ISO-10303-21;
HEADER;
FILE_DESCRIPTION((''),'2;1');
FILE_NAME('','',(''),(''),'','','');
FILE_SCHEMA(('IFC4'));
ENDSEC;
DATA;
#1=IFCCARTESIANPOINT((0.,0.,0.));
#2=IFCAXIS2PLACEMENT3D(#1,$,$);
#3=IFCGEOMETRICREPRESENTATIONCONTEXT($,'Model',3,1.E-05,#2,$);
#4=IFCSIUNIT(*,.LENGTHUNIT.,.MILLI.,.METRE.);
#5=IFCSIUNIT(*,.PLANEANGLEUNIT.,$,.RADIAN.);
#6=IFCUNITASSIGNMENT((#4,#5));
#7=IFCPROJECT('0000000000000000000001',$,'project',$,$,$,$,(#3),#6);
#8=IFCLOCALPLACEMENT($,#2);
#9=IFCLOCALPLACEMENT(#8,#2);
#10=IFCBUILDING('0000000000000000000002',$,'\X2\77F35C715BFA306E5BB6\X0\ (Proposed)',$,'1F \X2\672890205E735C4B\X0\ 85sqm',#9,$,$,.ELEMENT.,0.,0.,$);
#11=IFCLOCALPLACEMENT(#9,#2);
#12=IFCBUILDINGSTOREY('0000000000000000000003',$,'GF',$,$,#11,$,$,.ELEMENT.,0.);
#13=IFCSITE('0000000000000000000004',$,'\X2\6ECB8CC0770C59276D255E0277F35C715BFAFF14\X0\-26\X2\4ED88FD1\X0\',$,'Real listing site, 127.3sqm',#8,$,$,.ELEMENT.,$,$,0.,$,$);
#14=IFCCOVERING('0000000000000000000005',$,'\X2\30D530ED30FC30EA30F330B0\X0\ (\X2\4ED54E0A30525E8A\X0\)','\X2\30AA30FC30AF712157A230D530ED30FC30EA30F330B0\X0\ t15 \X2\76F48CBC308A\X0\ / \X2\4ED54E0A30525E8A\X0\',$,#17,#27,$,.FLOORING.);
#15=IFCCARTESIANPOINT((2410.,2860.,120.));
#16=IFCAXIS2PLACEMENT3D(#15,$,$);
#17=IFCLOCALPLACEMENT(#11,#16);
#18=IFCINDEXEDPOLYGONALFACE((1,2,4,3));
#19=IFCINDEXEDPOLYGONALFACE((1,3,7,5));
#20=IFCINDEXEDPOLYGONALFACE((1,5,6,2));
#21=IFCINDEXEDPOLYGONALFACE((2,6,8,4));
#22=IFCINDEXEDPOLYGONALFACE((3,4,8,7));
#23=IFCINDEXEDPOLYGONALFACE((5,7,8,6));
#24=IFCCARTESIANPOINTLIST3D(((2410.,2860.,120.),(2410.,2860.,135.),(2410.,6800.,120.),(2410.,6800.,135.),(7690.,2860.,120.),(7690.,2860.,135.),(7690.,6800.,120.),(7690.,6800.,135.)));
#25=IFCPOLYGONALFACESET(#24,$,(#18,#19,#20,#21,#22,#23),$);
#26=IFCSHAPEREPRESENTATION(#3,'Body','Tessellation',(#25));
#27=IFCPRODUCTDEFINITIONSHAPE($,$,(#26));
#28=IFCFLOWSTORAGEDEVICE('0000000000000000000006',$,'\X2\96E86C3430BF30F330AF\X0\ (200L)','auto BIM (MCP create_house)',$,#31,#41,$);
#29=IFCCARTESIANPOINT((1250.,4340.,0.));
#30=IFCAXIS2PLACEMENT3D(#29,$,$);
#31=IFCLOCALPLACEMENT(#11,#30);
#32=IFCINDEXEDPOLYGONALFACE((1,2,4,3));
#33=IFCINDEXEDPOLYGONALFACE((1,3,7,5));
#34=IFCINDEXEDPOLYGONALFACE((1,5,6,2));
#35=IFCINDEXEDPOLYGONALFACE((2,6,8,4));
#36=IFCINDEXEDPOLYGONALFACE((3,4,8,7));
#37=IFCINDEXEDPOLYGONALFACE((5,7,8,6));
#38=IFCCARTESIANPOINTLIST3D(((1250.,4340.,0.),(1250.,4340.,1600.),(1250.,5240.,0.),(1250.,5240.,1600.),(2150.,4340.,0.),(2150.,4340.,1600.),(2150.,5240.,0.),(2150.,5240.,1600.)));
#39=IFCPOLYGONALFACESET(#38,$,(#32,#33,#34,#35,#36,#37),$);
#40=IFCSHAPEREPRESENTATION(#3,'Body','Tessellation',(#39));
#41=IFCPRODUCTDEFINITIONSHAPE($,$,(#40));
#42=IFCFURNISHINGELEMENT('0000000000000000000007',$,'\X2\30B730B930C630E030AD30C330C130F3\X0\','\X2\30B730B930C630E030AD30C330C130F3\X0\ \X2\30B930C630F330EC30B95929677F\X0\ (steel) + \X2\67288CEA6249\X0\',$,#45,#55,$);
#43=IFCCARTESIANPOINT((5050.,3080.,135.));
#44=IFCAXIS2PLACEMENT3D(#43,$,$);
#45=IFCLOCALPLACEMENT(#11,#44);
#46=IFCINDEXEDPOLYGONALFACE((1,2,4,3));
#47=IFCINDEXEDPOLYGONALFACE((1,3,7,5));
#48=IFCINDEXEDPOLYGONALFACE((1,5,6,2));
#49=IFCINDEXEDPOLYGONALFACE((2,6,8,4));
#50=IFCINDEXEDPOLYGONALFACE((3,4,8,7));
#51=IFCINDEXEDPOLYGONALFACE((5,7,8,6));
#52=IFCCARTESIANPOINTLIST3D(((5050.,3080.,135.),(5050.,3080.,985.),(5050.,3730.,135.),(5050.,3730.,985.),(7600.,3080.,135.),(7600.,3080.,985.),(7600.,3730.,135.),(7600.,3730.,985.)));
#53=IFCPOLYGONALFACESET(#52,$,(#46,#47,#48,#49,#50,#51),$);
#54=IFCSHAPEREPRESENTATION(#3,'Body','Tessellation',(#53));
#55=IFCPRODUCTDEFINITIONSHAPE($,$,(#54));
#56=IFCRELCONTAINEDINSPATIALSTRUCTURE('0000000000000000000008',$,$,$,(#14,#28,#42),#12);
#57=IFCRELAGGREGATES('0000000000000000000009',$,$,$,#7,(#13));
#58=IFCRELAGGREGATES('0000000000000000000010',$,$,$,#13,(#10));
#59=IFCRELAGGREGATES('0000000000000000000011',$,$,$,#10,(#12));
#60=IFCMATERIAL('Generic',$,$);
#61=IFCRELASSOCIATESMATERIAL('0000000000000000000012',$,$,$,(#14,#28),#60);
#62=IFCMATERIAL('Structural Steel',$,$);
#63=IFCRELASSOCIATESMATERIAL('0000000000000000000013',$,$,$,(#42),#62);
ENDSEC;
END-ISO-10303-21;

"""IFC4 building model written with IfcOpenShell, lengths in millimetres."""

from ifc_helpers import new_model, si_unit, frame, frame_2d, origin, place, context, project, spatial, rectangle, extrude, material, element, save


model = new_model("IFC4")

# Units and contexts
model_context = context("Model", 3, precision=1e-05, world=origin())
ifc_project = project(units=[si_unit("LENGTHUNIT", "METRE", prefix="MILLI"), si_unit("PLANEANGLEUNIT", "RADIAN")], contexts=[model_context])

# Site, building, storey
site_placement = place(None, origin())
site = spatial("IfcSite", under=ifc_project, at=site_placement, Name="滋賀県大津市石山寺４-26付近", ObjectType="Real listing site, 127.3sqm", CompositionType="ELEMENT", RefElevation=0.0)
building_placement = place(site_placement, origin())
building = spatial("IfcBuilding", under=site, at=building_placement, Name="石山寺の家 (Proposed)", ObjectType="1F 木造平屋 85sqm", CompositionType="ELEMENT", ElevationOfRefHeight=0.0, ElevationOfTerrain=0.0)
storey_placement = place(building_placement, origin())
storey = spatial("IfcBuildingStorey", under=building, at=storey_placement, Name="GF", CompositionType="ELEMENT", Elevation=0.0)

# Shared definitions
ifc_material_1 = material(Name="Generic")

# Covering
covering_placement = place(storey_placement, frame((2410.0, 2860.0, 120.0)))
element("IfcCovering", 1, at=covering_placement, inside=storey, material=ifc_material_1, Name="フローリング (仕上げ床)", Description="オーク無垢フローリング t15 直貼り / 仕上げ床", PredefinedType="FLOORING", context=model_context, shape_type="SweptSolid", body=[
    extrude(rectangle(XDim=5280.0, YDim=3940.0, at=frame_2d((2640.0, 1970.0))), frame((2410.0, 2860.0, 120.0)), (0.0, 0.0, 1.0), 15.0),
])

# Flow storage device
flow_storage_device_placement = place(storey_placement, frame((1250.0, 4340.0, 0.0)))
element("IfcFlowStorageDevice", 2, at=flow_storage_device_placement, inside=storey, material=ifc_material_1, Name="雨水タンク (200L)", Description="auto BIM (MCP create_house)", context=model_context, shape_type="SweptSolid", body=[
    extrude(rectangle(XDim=900.0, YDim=900.0, at=frame_2d((450.0, 450.0))), frame((1250.0, 4340.0, 0.0)), (0.0, 0.0, 1.0), 1600.0),
])

# Furnishing element
ifc_material_2 = material(Name="Structural Steel")
furnishing_placement = place(storey_placement, frame((5050.0, 3080.0, 135.0)))
element("IfcFurnishingElement", 3, at=furnishing_placement, inside=storey, material=ifc_material_2, Name="システムキッチン", Description="システムキッチン ステンレス天板 (steel) + 木質扉", context=model_context, shape_type="SweptSolid", body=[
    extrude(rectangle(XDim=2550.0, YDim=650.0, at=frame_2d((1275.0, 325.0))), frame((5050.0, 3080.0, 135.0)), (0.0, 0.0, 1.0), 850.0),
])

save(model, "model.ifc")
